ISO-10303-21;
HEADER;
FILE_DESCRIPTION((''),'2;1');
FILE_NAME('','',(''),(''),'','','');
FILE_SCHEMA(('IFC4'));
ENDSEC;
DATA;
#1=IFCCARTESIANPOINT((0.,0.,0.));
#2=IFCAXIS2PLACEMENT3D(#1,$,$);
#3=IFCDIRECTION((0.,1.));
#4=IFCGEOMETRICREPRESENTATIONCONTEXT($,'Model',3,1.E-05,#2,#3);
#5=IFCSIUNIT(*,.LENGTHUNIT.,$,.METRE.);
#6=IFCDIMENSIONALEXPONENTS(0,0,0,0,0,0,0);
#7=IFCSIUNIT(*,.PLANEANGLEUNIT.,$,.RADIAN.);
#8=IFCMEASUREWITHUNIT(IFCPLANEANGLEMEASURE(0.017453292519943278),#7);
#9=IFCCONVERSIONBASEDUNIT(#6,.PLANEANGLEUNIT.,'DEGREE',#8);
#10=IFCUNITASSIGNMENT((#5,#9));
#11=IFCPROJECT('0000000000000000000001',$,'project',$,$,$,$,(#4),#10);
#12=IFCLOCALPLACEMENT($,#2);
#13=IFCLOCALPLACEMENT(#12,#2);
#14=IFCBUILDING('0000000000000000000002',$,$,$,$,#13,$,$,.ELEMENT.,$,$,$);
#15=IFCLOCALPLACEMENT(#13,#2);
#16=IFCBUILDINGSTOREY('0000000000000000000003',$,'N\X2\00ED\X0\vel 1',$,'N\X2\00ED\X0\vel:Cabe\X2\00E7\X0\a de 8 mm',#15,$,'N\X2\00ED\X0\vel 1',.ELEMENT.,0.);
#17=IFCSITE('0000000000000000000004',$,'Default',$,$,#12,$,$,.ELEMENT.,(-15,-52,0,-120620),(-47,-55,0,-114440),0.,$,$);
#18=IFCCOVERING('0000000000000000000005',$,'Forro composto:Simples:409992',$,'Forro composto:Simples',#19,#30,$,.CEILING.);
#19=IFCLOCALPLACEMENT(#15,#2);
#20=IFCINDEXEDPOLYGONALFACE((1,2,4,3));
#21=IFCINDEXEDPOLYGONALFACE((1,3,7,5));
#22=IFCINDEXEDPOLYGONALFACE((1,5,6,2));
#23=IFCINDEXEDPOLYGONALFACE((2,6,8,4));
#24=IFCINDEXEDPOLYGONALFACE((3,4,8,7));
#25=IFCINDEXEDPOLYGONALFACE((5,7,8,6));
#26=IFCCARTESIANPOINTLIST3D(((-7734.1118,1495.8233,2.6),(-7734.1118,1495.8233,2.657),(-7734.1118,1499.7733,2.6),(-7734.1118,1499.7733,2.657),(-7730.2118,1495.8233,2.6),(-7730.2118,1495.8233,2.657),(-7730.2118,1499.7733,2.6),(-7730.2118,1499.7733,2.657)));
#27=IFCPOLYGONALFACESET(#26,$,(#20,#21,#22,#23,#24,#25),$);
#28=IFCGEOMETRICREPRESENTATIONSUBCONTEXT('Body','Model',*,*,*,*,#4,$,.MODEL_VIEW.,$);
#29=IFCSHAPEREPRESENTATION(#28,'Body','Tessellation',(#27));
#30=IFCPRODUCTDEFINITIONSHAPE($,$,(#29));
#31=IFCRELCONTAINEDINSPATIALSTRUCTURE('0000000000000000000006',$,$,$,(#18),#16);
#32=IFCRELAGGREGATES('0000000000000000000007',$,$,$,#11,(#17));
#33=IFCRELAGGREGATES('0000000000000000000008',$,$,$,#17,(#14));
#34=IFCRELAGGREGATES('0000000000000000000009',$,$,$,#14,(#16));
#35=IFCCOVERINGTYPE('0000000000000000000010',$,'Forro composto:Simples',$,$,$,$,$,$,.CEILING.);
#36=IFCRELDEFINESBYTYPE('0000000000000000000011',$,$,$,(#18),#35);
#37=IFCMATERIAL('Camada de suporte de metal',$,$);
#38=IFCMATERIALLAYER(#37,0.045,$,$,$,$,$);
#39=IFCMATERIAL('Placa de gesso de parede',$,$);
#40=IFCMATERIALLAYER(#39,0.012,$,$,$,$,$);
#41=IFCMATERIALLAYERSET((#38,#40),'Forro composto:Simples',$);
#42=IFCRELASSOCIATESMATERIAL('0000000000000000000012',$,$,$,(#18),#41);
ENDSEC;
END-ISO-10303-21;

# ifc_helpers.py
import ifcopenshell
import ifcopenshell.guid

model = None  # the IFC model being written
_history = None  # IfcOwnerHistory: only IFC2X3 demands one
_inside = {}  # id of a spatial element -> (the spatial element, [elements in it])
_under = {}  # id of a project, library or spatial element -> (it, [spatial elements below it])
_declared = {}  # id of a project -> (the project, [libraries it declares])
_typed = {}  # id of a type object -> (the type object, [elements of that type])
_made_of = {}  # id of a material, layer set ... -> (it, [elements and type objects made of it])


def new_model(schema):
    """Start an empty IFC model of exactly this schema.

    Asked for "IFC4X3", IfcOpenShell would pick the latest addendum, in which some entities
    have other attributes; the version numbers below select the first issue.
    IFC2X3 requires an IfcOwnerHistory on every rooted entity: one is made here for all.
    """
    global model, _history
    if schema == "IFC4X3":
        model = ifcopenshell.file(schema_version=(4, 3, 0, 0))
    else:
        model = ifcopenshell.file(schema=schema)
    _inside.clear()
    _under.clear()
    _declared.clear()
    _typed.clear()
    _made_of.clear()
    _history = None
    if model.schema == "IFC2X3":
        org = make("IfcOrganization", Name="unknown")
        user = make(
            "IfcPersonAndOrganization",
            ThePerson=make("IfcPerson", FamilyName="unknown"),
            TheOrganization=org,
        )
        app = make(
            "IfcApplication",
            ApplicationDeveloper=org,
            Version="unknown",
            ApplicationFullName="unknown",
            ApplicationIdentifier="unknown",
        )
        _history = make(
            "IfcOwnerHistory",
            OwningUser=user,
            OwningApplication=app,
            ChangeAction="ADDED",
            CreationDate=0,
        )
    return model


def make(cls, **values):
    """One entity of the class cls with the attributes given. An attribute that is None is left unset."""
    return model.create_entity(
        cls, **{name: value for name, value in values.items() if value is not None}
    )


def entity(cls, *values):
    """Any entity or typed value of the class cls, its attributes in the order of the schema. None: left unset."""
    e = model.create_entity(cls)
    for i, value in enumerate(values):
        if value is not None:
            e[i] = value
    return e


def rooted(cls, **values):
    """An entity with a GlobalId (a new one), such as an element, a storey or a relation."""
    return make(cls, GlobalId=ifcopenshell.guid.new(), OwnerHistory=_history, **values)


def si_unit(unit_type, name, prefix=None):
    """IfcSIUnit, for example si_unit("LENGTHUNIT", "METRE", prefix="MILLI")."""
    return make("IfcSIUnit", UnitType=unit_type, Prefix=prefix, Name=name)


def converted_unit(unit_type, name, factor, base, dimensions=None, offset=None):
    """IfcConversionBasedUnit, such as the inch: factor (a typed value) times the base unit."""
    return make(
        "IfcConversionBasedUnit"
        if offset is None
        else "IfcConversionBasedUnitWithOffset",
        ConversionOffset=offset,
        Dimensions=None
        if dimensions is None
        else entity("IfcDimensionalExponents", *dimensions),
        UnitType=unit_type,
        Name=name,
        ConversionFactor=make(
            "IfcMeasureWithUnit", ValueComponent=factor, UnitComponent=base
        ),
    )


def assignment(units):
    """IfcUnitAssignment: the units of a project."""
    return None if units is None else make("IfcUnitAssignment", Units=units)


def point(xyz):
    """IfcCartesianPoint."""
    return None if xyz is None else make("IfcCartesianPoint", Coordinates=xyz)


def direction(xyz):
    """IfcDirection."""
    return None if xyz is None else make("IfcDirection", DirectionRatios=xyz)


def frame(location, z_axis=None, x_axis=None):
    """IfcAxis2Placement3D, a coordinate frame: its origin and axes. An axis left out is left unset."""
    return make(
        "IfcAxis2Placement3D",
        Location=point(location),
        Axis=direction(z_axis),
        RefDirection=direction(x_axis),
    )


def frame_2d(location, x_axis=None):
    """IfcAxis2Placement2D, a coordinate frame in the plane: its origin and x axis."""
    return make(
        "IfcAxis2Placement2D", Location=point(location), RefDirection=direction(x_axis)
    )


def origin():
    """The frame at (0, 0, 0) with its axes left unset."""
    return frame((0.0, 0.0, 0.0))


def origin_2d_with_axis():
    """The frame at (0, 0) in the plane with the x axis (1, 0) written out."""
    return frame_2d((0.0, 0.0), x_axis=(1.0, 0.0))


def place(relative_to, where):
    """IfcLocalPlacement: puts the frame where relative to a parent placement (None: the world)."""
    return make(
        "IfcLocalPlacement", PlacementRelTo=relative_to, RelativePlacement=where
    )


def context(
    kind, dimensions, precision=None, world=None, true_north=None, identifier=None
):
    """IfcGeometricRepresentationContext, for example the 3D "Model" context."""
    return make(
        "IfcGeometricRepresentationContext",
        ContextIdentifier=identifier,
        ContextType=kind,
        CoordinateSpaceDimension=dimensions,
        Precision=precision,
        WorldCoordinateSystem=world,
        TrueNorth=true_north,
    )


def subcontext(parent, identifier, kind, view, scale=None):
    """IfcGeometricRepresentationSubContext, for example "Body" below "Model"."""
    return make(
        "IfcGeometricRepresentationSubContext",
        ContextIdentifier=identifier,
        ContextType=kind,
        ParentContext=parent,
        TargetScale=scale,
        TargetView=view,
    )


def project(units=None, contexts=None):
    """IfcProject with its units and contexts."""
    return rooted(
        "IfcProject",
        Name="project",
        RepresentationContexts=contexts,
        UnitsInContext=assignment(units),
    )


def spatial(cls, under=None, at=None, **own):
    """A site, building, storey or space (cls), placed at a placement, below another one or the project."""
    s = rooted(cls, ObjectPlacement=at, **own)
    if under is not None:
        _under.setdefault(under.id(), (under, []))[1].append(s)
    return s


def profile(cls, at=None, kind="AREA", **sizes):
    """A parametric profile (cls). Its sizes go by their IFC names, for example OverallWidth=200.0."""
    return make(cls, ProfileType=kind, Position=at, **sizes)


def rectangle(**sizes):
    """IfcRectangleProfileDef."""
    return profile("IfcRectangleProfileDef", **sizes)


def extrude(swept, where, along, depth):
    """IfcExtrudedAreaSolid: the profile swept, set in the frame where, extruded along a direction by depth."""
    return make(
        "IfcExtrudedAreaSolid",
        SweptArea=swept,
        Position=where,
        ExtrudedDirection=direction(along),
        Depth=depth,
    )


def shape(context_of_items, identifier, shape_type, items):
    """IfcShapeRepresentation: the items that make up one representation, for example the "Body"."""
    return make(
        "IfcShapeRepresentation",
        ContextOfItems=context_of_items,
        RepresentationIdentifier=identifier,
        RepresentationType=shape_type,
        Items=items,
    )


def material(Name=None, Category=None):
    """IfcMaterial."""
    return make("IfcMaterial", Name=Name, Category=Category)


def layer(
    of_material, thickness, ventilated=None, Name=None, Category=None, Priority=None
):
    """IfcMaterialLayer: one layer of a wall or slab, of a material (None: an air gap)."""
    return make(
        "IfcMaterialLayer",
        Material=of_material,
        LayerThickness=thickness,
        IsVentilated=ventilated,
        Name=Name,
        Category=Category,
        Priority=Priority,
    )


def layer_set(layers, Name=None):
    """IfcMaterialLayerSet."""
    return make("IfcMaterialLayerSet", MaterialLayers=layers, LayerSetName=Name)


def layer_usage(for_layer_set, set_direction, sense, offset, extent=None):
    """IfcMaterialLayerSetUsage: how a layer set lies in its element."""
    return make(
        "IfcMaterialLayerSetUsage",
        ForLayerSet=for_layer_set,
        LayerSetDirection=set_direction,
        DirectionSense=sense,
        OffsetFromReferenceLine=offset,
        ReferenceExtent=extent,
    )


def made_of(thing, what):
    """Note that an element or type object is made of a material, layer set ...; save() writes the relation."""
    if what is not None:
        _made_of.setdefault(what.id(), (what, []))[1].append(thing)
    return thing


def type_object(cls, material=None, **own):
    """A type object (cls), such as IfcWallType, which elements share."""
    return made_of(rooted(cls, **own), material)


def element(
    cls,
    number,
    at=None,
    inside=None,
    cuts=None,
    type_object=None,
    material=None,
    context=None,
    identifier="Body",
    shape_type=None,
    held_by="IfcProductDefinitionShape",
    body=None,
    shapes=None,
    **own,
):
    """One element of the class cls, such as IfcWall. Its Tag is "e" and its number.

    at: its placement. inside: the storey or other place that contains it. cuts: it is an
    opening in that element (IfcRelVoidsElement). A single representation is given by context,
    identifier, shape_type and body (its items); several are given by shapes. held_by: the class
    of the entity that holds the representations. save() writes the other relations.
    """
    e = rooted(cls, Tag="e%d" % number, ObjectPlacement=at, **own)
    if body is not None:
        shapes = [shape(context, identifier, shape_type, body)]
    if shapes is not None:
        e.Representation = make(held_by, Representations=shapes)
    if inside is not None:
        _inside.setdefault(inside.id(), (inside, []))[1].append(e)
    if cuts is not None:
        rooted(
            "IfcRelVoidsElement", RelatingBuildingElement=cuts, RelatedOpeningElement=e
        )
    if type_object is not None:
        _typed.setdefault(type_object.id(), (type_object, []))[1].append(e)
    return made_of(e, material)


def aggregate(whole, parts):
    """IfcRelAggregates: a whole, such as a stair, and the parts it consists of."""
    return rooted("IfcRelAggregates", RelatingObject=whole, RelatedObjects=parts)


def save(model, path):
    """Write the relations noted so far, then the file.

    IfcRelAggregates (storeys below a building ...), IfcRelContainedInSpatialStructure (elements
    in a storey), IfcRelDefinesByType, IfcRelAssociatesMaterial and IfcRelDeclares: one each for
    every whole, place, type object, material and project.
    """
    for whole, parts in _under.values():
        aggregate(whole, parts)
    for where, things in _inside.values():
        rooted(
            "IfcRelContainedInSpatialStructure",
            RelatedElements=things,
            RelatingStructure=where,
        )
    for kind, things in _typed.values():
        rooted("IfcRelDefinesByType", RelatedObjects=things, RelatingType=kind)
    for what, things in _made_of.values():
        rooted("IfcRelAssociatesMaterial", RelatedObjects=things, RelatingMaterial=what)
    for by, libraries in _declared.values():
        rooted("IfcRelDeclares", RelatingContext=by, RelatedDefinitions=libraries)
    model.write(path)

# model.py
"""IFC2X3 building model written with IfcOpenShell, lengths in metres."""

from ifc_helpers import new_model, entity, si_unit, converted_unit, direction, frame, origin, origin_2d_with_axis, place, context, subcontext, project, spatial, rectangle, extrude, material, layer, layer_set, layer_usage, type_object, element, save


model = new_model("IFC2X3")

# Units and contexts
model_context = context("Model", 3, precision=1e-05, world=origin(), true_north=direction((0.0, 1.0)))
body_context = subcontext(model_context, "Body", "Model", "MODEL_VIEW")
ifc_project = project(units=[si_unit("LENGTHUNIT", "METRE"), converted_unit("PLANEANGLEUNIT", "DEGREE", entity("IfcPlaneAngleMeasure", 0.017453292519943278), si_unit("PLANEANGLEUNIT", "RADIAN"), dimensions=[0, 0, 0, 0, 0, 0, 0])], contexts=[model_context])

# Site, building, storey
site_placement = place(None, origin())
site = spatial("IfcSite", under=ifc_project, at=site_placement, Name="Default", CompositionType="ELEMENT", RefLatitude=(-15, -52, 0, -120620), RefLongitude=(-47, -55, 0, -114440), RefElevation=0.0)
building_placement = place(site_placement, origin())
building = spatial("IfcBuilding", under=site, at=building_placement, CompositionType="ELEMENT")
storey_placement = place(building_placement, origin())
storey = spatial("IfcBuildingStorey", under=building, at=storey_placement, Name="Nível 1", ObjectType="Nível:Cabeça de 8 mm", LongName="Nível 1", CompositionType="ELEMENT", Elevation=0.0)

# Covering
ifc_material_1 = material(Name="Camada de suporte de metal")
ifc_layer_1 = layer(ifc_material_1, 0.045)
ifc_material_2 = material(Name="Placa de gesso de parede")
ifc_layer_2 = layer(ifc_material_2, 0.012)
ifc_layer_set_1 = layer_set([ifc_layer_1, ifc_layer_2], Name="Forro composto:Simples")
covering_type = type_object("IfcCoveringType", Name="Forro composto:Simples", PredefinedType="CEILING")
ifc_layer_usage_1 = layer_usage(ifc_layer_set_1, "AXIS3", "NEGATIVE", 0.057)
covering_1_placement = place(storey_placement, origin())
element("IfcCovering", 1, at=covering_1_placement, inside=storey, type_object=covering_type, material=ifc_layer_usage_1, Name="Forro composto:Simples:409992", ObjectType="Forro composto:Simples", PredefinedType="CEILING", context=body_context, shape_type="SweptSolid", body=[
    extrude(rectangle(XDim=3.9, YDim=3.95, at=origin_2d_with_axis()), frame((-7732.1618, 1497.7983, 2.6), z_axis=(0.0, 0.0, 1.0), x_axis=(-1.0, 0.0, 0.0)), (0.0, 0.0, 1.0), 0.057),
])

save(model, "model.ifc")
